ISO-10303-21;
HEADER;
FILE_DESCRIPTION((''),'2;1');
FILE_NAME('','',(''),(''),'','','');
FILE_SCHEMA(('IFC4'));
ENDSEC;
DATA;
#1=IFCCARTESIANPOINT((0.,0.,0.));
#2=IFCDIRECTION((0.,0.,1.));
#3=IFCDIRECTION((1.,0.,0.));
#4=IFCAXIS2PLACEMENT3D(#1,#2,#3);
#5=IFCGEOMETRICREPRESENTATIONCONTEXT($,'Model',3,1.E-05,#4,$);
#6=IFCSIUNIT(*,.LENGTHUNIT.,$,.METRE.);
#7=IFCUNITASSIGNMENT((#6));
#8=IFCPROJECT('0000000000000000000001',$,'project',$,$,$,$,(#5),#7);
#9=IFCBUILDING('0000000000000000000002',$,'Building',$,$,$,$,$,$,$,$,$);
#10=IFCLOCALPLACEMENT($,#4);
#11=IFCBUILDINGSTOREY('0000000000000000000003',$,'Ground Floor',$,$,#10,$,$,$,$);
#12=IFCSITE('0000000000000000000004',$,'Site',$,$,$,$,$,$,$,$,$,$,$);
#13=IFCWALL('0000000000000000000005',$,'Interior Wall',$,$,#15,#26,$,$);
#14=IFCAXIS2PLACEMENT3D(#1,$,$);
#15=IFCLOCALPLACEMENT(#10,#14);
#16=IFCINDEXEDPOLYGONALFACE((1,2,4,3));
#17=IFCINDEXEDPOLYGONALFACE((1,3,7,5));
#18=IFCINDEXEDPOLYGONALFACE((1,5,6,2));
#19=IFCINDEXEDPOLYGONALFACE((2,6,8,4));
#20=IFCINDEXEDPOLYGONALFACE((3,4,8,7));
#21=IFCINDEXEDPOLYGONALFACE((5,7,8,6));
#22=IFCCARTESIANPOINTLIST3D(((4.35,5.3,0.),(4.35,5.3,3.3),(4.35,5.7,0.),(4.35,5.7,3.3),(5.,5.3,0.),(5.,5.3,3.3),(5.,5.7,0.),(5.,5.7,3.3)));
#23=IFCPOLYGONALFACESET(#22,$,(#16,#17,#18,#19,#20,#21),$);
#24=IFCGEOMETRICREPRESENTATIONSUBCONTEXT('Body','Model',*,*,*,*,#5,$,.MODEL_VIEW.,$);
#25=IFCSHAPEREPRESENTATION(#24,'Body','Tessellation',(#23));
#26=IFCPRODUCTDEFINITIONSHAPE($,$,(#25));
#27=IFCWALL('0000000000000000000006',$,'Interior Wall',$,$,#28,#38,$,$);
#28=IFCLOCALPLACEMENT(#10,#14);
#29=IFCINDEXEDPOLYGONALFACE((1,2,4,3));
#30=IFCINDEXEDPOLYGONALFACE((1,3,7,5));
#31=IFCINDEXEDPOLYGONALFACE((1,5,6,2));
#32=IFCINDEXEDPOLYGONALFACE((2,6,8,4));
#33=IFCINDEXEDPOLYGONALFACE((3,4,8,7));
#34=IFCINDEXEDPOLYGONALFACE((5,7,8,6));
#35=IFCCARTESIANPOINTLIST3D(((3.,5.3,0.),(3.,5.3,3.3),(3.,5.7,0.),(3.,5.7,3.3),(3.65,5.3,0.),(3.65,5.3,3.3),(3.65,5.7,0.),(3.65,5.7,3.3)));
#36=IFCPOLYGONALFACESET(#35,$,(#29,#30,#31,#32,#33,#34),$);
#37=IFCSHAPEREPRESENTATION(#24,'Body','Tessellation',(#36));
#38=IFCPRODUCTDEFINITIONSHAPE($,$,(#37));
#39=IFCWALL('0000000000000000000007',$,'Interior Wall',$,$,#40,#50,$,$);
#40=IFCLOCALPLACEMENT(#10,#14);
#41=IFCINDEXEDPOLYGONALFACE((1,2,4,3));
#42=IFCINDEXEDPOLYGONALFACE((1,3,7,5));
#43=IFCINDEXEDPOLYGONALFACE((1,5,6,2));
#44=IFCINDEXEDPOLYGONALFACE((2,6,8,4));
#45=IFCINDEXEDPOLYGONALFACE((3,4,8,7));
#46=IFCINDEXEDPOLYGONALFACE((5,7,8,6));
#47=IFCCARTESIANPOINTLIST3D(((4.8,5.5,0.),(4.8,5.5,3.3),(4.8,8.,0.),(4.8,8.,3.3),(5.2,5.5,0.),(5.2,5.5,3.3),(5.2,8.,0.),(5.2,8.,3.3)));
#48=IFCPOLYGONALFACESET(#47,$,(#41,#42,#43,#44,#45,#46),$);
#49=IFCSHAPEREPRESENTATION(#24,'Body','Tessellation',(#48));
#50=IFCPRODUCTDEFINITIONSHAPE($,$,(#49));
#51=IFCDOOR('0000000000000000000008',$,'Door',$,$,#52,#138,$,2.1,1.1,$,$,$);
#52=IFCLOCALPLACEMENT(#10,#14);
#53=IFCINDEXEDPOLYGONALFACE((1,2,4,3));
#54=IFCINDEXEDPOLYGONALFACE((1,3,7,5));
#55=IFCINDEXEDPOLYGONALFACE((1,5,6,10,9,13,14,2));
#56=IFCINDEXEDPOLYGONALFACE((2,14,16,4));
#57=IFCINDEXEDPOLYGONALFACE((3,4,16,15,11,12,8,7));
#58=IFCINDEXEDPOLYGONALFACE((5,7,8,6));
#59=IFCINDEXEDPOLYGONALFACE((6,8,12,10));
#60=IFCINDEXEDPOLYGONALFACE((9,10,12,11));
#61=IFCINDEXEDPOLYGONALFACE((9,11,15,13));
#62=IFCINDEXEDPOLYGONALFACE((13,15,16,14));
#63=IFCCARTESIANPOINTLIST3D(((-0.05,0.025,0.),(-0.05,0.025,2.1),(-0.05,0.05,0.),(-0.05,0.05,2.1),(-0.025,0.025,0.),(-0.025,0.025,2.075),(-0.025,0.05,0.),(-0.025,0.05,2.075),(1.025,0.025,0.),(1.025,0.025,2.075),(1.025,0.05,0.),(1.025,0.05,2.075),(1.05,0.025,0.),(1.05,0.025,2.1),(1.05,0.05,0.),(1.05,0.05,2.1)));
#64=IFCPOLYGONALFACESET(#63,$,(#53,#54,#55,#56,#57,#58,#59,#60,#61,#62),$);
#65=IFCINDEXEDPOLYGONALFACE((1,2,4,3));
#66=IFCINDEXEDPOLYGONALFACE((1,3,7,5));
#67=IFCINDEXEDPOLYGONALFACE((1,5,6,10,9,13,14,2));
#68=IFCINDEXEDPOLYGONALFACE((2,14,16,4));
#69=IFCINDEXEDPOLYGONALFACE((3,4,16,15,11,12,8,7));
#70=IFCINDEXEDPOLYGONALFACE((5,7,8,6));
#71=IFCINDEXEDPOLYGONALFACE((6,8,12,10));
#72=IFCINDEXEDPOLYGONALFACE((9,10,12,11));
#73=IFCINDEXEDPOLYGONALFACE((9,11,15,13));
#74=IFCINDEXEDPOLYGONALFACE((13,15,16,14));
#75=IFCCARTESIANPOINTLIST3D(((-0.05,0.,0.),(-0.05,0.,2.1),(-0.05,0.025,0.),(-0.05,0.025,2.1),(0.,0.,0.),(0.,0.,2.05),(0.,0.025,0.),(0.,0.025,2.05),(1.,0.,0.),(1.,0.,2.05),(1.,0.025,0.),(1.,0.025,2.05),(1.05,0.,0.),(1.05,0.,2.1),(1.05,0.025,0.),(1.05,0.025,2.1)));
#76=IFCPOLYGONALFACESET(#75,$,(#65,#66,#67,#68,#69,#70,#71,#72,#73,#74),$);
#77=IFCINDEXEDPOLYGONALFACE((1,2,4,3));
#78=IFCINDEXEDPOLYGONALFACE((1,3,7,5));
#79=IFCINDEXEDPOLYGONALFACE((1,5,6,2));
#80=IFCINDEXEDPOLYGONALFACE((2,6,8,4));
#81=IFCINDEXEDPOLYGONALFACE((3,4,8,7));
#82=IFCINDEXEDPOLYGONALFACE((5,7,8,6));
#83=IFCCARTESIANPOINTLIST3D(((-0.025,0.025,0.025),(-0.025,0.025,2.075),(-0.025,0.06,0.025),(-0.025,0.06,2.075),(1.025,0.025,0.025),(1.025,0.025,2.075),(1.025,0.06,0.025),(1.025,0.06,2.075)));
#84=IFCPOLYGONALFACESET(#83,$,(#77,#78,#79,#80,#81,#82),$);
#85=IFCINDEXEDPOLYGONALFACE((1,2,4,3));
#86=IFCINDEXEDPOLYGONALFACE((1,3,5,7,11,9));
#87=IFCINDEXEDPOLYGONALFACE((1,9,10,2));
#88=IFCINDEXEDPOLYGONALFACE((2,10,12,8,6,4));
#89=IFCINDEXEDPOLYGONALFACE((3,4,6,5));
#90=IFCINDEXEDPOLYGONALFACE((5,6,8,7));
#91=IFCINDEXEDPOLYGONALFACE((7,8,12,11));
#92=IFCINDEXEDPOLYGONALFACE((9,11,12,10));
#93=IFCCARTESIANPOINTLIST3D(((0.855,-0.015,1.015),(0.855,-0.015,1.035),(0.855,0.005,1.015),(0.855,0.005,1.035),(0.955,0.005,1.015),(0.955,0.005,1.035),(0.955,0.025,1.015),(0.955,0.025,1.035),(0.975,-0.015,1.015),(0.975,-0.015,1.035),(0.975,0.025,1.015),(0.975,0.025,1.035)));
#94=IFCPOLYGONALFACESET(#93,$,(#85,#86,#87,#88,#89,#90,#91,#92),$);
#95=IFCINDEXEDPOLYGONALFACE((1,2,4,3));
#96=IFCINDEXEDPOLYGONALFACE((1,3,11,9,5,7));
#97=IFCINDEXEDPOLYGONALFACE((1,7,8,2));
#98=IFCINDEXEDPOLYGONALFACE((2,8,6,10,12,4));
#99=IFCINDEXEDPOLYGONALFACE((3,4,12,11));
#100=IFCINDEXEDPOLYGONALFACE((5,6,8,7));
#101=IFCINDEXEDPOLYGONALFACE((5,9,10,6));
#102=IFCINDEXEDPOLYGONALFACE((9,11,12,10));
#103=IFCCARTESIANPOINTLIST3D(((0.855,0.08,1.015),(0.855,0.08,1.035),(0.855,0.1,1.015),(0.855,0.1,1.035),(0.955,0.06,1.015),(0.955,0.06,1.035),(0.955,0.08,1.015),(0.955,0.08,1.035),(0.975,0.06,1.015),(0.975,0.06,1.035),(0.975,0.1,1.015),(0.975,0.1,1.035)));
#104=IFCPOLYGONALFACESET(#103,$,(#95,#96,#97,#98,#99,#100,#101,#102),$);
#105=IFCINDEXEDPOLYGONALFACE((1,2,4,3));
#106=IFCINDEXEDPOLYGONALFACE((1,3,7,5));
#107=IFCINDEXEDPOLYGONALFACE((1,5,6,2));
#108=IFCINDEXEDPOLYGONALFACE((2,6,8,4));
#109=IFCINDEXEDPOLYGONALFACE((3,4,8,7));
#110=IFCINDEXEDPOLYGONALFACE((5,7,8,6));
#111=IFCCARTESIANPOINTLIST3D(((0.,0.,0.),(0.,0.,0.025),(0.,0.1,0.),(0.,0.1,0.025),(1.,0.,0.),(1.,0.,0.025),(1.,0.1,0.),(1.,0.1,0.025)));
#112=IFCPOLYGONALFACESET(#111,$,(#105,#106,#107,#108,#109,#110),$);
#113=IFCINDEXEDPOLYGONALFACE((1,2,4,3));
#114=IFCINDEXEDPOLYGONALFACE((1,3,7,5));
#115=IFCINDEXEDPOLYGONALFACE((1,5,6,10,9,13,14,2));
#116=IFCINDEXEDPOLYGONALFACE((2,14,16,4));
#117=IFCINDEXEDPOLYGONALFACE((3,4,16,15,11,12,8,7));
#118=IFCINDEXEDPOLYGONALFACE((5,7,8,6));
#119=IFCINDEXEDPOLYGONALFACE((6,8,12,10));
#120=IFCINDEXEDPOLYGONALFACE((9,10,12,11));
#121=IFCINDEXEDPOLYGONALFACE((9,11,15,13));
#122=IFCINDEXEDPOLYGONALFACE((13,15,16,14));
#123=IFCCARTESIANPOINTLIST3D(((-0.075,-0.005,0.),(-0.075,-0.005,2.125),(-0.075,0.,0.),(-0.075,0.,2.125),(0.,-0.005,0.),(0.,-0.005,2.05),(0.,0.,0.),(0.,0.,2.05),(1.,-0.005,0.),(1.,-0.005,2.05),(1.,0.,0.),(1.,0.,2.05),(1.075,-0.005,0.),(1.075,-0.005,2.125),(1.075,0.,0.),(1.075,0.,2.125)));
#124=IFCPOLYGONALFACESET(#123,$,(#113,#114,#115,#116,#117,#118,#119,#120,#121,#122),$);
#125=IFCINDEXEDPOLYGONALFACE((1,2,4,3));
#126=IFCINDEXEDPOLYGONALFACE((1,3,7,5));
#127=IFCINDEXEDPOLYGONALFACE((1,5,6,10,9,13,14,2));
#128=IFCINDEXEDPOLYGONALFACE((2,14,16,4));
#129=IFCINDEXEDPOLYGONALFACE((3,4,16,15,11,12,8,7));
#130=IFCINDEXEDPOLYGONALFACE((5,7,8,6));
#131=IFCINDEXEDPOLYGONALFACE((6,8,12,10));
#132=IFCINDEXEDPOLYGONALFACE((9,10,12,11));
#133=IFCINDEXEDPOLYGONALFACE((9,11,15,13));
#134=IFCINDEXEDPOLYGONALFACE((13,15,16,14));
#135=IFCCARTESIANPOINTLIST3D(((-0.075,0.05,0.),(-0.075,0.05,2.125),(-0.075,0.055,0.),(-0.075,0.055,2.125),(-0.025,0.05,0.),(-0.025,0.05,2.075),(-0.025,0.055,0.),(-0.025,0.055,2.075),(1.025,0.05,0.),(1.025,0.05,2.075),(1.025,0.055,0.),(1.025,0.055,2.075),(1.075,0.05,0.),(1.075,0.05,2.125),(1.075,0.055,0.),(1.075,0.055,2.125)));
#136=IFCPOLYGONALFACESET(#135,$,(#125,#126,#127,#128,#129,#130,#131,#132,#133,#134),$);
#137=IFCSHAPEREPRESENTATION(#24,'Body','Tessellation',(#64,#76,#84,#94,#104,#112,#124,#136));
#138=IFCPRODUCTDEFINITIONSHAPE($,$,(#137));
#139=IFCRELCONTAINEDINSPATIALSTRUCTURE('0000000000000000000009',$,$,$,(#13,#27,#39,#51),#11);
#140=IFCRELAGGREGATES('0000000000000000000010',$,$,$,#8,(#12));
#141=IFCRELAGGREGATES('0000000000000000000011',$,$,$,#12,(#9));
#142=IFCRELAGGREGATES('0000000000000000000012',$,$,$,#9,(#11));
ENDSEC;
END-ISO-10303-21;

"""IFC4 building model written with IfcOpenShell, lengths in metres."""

from ifc_helpers import new_model, si_unit, frame, origin_with_axes, place, context, subcontext, project, spatial, line, indexed_curve, outline, extrude, element, save


model = new_model("IFC4")

# Units and contexts
model_context = context("Model", 3, precision=1e-05, world=origin_with_axes())
body_context = subcontext(model_context, "Body", "Model", "MODEL_VIEW")
ifc_project = project(units=[si_unit("LENGTHUNIT", "METRE")], contexts=[model_context])

# Site, building, storey
site = spatial("IfcSite", under=ifc_project, Name="Site")
building = spatial("IfcBuilding", under=site, Name="Building")
storey_placement = place(None, origin_with_axes())
storey = spatial("IfcBuildingStorey", under=building, at=storey_placement, Name="Ground Floor")

# Walls
wall_1_placement = place(storey_placement, frame((5.0, 5.5, 0.0), z_axis=(0.0, 0.0, 1.0), x_axis=(-1.0, 0.0, 0.0)))
element("IfcWall", 1, at=wall_1_placement, inside=storey, Name="Interior Wall", context=body_context, shape_type="SweptSolid", body=[
    extrude(outline(indexed_curve([(0.0, 0.0), (0.0, 0.4), (0.65, 0.4), (0.65, 0.0), (0.0, 0.0)], self_intersect=False)), frame((0.0, -0.2, 0.0), z_axis=(0.0, 0.0, 1.0), x_axis=(1.0, 0.0, 0.0)), (0.0, 0.0, 1.0), 3.3),
])
wall_2_placement = place(storey_placement, frame((3.65, 5.5, 0.0), z_axis=(0.0, 0.0, 1.0), x_axis=(-1.0, 0.0, 0.0)))
element("IfcWall", 2, at=wall_2_placement, inside=storey, Name="Interior Wall", context=body_context, shape_type="SweptSolid", body=[
    extrude(outline(indexed_curve([(0.0, 0.0), (0.0, 0.4), (0.65, 0.4), (0.65, 0.0), (0.0, 0.0)], self_intersect=False)), frame((0.0, -0.2, 0.0), z_axis=(0.0, 0.0, 1.0), x_axis=(1.0, 0.0, 0.0)), (0.0, 0.0, 1.0), 3.3),
])
wall_3_placement = place(storey_placement, frame((5.0, 5.5, 0.0), z_axis=(0.0, 0.0, 1.0), x_axis=(0.0, 1.0, 0.0)))
element("IfcWall", 3, at=wall_3_placement, inside=storey, Name="Interior Wall", context=body_context, shape_type="SweptSolid", body=[
    extrude(outline(indexed_curve([(0.0, 0.0), (0.0, 0.4), (2.5, 0.4), (2.5, 0.0), (0.0, 0.0)], self_intersect=False)), frame((0.0, -0.2, 0.0), z_axis=(0.0, 0.0, 1.0), x_axis=(1.0, 0.0, 0.0)), (0.0, 0.0, 1.0), 3.3),
])

# Door
door_1_placement = place(storey_placement, frame((-0.05, 0.0, 0.0), z_axis=(0.0, 0.0, 1.0), x_axis=(1.0, 0.0, 0.0)))
element("IfcDoor", 4, at=door_1_placement, inside=storey, Name="Door", OverallHeight=2.1, OverallWidth=1.1, context=body_context, shape_type="SweptSolid", body=[
    extrude(outline(indexed_curve([(0.0, 0.0), (0.0, 2.1), (1.1, 2.1), (1.1, 0.0), (1.075, 0.0), (1.075, 2.075), (0.025, 2.075), (0.025, 0.0)], segments=[line(1, 2, 3, 4, 5, 6, 7, 8, 1)])), frame((0.0, 0.025, 0.0), z_axis=(0.0, -1.0, 0.0), x_axis=(1.0, 0.0, 0.0)), (0.0, 0.0, -1.0), 0.025),
    extrude(outline(indexed_curve([(0.0, 0.0), (0.0, 2.1), (1.1, 2.1), (1.1, 0.0), (1.05, 0.0), (1.05, 2.05), (0.05, 2.05), (0.05, 0.0)], segments=[line(1, 2, 3, 4, 5, 6, 7, 8, 1)])), frame((0.0, 0.0, 0.0), z_axis=(0.0, -1.0, 0.0), x_axis=(1.0, 0.0, 0.0)), (0.0, 0.0, -1.0), 0.025),
    extrude(outline(indexed_curve([(0.0, 0.0), (1.05, 0.0), (1.05, 0.035), (0.0, 0.035)], segments=[line(1, 2, 3, 4, 1)])), frame((0.025, 0.025, 0.025), z_axis=(0.0, 0.0, 1.0), x_axis=(1.0, 0.0, 0.0)), (0.0, 0.0, 1.0), 2.05),
    extrude(outline(indexed_curve([(0.0, 0.0), (0.0, -0.04), (-0.12, -0.04), (-0.12, -0.02), (-0.02, -0.02), (-0.02, 0.0)], segments=[line(1, 2, 3, 4, 5, 6, 1)])), frame((1.025, 0.025, 1.015), z_axis=(0.0, 0.0, 1.0), x_axis=(1.0, 0.0, 0.0)), (0.0, 0.0, 1.0), 0.02),
    extrude(outline(indexed_curve([(0.0, 0.0), (0.0, 0.04), (-0.12, 0.04), (-0.12, 0.02), (-0.02, 0.02), (-0.02, 0.0)], segments=[line(1, 2, 3, 4, 5, 6, 1)])), frame((1.025, 0.06, 1.015), z_axis=(0.0, 0.0, 1.0), x_axis=(1.0, 0.0, 0.0)), (0.0, 0.0, 1.0), 0.02),
    extrude(outline(indexed_curve([(0.0, 0.0), (1.0, 0.0), (1.0, 0.1), (0.0, 0.1)], segments=[line(1, 2, 3, 4, 1)])), frame((0.05, 0.0, 0.0), z_axis=(0.0, 0.0, 1.0), x_axis=(1.0, 0.0, 0.0)), (0.0, 0.0, 1.0), 0.025),
    extrude(outline(indexed_curve([(0.0, 0.0), (0.0, 2.125), (1.15, 2.125), (1.15, 0.0), (1.075, 0.0), (1.075, 2.05), (0.075, 2.05), (0.075, 0.0)], segments=[line(1, 2, 3, 4, 5, 6, 7, 8, 1)])), frame((-0.025, -0.005, 0.0), z_axis=(0.0, -1.0, 0.0), x_axis=(1.0, 0.0, 0.0)), (0.0, 0.0, -1.0), 0.005),
    extrude(outline(indexed_curve([(0.0, 0.0), (0.0, 2.125), (1.15, 2.125), (1.15, 0.0), (1.1, 0.0), (1.1, 2.075), (0.05, 2.075), (0.05, 0.0)], segments=[line(1, 2, 3, 4, 5, 6, 7, 8, 1)])), frame((-0.025, 0.05, 0.0), z_axis=(0.0, -1.0, 0.0), x_axis=(1.0, 0.0, 0.0)), (0.0, 0.0, -1.0), 0.005),
])

save(model, "model.ifc")
